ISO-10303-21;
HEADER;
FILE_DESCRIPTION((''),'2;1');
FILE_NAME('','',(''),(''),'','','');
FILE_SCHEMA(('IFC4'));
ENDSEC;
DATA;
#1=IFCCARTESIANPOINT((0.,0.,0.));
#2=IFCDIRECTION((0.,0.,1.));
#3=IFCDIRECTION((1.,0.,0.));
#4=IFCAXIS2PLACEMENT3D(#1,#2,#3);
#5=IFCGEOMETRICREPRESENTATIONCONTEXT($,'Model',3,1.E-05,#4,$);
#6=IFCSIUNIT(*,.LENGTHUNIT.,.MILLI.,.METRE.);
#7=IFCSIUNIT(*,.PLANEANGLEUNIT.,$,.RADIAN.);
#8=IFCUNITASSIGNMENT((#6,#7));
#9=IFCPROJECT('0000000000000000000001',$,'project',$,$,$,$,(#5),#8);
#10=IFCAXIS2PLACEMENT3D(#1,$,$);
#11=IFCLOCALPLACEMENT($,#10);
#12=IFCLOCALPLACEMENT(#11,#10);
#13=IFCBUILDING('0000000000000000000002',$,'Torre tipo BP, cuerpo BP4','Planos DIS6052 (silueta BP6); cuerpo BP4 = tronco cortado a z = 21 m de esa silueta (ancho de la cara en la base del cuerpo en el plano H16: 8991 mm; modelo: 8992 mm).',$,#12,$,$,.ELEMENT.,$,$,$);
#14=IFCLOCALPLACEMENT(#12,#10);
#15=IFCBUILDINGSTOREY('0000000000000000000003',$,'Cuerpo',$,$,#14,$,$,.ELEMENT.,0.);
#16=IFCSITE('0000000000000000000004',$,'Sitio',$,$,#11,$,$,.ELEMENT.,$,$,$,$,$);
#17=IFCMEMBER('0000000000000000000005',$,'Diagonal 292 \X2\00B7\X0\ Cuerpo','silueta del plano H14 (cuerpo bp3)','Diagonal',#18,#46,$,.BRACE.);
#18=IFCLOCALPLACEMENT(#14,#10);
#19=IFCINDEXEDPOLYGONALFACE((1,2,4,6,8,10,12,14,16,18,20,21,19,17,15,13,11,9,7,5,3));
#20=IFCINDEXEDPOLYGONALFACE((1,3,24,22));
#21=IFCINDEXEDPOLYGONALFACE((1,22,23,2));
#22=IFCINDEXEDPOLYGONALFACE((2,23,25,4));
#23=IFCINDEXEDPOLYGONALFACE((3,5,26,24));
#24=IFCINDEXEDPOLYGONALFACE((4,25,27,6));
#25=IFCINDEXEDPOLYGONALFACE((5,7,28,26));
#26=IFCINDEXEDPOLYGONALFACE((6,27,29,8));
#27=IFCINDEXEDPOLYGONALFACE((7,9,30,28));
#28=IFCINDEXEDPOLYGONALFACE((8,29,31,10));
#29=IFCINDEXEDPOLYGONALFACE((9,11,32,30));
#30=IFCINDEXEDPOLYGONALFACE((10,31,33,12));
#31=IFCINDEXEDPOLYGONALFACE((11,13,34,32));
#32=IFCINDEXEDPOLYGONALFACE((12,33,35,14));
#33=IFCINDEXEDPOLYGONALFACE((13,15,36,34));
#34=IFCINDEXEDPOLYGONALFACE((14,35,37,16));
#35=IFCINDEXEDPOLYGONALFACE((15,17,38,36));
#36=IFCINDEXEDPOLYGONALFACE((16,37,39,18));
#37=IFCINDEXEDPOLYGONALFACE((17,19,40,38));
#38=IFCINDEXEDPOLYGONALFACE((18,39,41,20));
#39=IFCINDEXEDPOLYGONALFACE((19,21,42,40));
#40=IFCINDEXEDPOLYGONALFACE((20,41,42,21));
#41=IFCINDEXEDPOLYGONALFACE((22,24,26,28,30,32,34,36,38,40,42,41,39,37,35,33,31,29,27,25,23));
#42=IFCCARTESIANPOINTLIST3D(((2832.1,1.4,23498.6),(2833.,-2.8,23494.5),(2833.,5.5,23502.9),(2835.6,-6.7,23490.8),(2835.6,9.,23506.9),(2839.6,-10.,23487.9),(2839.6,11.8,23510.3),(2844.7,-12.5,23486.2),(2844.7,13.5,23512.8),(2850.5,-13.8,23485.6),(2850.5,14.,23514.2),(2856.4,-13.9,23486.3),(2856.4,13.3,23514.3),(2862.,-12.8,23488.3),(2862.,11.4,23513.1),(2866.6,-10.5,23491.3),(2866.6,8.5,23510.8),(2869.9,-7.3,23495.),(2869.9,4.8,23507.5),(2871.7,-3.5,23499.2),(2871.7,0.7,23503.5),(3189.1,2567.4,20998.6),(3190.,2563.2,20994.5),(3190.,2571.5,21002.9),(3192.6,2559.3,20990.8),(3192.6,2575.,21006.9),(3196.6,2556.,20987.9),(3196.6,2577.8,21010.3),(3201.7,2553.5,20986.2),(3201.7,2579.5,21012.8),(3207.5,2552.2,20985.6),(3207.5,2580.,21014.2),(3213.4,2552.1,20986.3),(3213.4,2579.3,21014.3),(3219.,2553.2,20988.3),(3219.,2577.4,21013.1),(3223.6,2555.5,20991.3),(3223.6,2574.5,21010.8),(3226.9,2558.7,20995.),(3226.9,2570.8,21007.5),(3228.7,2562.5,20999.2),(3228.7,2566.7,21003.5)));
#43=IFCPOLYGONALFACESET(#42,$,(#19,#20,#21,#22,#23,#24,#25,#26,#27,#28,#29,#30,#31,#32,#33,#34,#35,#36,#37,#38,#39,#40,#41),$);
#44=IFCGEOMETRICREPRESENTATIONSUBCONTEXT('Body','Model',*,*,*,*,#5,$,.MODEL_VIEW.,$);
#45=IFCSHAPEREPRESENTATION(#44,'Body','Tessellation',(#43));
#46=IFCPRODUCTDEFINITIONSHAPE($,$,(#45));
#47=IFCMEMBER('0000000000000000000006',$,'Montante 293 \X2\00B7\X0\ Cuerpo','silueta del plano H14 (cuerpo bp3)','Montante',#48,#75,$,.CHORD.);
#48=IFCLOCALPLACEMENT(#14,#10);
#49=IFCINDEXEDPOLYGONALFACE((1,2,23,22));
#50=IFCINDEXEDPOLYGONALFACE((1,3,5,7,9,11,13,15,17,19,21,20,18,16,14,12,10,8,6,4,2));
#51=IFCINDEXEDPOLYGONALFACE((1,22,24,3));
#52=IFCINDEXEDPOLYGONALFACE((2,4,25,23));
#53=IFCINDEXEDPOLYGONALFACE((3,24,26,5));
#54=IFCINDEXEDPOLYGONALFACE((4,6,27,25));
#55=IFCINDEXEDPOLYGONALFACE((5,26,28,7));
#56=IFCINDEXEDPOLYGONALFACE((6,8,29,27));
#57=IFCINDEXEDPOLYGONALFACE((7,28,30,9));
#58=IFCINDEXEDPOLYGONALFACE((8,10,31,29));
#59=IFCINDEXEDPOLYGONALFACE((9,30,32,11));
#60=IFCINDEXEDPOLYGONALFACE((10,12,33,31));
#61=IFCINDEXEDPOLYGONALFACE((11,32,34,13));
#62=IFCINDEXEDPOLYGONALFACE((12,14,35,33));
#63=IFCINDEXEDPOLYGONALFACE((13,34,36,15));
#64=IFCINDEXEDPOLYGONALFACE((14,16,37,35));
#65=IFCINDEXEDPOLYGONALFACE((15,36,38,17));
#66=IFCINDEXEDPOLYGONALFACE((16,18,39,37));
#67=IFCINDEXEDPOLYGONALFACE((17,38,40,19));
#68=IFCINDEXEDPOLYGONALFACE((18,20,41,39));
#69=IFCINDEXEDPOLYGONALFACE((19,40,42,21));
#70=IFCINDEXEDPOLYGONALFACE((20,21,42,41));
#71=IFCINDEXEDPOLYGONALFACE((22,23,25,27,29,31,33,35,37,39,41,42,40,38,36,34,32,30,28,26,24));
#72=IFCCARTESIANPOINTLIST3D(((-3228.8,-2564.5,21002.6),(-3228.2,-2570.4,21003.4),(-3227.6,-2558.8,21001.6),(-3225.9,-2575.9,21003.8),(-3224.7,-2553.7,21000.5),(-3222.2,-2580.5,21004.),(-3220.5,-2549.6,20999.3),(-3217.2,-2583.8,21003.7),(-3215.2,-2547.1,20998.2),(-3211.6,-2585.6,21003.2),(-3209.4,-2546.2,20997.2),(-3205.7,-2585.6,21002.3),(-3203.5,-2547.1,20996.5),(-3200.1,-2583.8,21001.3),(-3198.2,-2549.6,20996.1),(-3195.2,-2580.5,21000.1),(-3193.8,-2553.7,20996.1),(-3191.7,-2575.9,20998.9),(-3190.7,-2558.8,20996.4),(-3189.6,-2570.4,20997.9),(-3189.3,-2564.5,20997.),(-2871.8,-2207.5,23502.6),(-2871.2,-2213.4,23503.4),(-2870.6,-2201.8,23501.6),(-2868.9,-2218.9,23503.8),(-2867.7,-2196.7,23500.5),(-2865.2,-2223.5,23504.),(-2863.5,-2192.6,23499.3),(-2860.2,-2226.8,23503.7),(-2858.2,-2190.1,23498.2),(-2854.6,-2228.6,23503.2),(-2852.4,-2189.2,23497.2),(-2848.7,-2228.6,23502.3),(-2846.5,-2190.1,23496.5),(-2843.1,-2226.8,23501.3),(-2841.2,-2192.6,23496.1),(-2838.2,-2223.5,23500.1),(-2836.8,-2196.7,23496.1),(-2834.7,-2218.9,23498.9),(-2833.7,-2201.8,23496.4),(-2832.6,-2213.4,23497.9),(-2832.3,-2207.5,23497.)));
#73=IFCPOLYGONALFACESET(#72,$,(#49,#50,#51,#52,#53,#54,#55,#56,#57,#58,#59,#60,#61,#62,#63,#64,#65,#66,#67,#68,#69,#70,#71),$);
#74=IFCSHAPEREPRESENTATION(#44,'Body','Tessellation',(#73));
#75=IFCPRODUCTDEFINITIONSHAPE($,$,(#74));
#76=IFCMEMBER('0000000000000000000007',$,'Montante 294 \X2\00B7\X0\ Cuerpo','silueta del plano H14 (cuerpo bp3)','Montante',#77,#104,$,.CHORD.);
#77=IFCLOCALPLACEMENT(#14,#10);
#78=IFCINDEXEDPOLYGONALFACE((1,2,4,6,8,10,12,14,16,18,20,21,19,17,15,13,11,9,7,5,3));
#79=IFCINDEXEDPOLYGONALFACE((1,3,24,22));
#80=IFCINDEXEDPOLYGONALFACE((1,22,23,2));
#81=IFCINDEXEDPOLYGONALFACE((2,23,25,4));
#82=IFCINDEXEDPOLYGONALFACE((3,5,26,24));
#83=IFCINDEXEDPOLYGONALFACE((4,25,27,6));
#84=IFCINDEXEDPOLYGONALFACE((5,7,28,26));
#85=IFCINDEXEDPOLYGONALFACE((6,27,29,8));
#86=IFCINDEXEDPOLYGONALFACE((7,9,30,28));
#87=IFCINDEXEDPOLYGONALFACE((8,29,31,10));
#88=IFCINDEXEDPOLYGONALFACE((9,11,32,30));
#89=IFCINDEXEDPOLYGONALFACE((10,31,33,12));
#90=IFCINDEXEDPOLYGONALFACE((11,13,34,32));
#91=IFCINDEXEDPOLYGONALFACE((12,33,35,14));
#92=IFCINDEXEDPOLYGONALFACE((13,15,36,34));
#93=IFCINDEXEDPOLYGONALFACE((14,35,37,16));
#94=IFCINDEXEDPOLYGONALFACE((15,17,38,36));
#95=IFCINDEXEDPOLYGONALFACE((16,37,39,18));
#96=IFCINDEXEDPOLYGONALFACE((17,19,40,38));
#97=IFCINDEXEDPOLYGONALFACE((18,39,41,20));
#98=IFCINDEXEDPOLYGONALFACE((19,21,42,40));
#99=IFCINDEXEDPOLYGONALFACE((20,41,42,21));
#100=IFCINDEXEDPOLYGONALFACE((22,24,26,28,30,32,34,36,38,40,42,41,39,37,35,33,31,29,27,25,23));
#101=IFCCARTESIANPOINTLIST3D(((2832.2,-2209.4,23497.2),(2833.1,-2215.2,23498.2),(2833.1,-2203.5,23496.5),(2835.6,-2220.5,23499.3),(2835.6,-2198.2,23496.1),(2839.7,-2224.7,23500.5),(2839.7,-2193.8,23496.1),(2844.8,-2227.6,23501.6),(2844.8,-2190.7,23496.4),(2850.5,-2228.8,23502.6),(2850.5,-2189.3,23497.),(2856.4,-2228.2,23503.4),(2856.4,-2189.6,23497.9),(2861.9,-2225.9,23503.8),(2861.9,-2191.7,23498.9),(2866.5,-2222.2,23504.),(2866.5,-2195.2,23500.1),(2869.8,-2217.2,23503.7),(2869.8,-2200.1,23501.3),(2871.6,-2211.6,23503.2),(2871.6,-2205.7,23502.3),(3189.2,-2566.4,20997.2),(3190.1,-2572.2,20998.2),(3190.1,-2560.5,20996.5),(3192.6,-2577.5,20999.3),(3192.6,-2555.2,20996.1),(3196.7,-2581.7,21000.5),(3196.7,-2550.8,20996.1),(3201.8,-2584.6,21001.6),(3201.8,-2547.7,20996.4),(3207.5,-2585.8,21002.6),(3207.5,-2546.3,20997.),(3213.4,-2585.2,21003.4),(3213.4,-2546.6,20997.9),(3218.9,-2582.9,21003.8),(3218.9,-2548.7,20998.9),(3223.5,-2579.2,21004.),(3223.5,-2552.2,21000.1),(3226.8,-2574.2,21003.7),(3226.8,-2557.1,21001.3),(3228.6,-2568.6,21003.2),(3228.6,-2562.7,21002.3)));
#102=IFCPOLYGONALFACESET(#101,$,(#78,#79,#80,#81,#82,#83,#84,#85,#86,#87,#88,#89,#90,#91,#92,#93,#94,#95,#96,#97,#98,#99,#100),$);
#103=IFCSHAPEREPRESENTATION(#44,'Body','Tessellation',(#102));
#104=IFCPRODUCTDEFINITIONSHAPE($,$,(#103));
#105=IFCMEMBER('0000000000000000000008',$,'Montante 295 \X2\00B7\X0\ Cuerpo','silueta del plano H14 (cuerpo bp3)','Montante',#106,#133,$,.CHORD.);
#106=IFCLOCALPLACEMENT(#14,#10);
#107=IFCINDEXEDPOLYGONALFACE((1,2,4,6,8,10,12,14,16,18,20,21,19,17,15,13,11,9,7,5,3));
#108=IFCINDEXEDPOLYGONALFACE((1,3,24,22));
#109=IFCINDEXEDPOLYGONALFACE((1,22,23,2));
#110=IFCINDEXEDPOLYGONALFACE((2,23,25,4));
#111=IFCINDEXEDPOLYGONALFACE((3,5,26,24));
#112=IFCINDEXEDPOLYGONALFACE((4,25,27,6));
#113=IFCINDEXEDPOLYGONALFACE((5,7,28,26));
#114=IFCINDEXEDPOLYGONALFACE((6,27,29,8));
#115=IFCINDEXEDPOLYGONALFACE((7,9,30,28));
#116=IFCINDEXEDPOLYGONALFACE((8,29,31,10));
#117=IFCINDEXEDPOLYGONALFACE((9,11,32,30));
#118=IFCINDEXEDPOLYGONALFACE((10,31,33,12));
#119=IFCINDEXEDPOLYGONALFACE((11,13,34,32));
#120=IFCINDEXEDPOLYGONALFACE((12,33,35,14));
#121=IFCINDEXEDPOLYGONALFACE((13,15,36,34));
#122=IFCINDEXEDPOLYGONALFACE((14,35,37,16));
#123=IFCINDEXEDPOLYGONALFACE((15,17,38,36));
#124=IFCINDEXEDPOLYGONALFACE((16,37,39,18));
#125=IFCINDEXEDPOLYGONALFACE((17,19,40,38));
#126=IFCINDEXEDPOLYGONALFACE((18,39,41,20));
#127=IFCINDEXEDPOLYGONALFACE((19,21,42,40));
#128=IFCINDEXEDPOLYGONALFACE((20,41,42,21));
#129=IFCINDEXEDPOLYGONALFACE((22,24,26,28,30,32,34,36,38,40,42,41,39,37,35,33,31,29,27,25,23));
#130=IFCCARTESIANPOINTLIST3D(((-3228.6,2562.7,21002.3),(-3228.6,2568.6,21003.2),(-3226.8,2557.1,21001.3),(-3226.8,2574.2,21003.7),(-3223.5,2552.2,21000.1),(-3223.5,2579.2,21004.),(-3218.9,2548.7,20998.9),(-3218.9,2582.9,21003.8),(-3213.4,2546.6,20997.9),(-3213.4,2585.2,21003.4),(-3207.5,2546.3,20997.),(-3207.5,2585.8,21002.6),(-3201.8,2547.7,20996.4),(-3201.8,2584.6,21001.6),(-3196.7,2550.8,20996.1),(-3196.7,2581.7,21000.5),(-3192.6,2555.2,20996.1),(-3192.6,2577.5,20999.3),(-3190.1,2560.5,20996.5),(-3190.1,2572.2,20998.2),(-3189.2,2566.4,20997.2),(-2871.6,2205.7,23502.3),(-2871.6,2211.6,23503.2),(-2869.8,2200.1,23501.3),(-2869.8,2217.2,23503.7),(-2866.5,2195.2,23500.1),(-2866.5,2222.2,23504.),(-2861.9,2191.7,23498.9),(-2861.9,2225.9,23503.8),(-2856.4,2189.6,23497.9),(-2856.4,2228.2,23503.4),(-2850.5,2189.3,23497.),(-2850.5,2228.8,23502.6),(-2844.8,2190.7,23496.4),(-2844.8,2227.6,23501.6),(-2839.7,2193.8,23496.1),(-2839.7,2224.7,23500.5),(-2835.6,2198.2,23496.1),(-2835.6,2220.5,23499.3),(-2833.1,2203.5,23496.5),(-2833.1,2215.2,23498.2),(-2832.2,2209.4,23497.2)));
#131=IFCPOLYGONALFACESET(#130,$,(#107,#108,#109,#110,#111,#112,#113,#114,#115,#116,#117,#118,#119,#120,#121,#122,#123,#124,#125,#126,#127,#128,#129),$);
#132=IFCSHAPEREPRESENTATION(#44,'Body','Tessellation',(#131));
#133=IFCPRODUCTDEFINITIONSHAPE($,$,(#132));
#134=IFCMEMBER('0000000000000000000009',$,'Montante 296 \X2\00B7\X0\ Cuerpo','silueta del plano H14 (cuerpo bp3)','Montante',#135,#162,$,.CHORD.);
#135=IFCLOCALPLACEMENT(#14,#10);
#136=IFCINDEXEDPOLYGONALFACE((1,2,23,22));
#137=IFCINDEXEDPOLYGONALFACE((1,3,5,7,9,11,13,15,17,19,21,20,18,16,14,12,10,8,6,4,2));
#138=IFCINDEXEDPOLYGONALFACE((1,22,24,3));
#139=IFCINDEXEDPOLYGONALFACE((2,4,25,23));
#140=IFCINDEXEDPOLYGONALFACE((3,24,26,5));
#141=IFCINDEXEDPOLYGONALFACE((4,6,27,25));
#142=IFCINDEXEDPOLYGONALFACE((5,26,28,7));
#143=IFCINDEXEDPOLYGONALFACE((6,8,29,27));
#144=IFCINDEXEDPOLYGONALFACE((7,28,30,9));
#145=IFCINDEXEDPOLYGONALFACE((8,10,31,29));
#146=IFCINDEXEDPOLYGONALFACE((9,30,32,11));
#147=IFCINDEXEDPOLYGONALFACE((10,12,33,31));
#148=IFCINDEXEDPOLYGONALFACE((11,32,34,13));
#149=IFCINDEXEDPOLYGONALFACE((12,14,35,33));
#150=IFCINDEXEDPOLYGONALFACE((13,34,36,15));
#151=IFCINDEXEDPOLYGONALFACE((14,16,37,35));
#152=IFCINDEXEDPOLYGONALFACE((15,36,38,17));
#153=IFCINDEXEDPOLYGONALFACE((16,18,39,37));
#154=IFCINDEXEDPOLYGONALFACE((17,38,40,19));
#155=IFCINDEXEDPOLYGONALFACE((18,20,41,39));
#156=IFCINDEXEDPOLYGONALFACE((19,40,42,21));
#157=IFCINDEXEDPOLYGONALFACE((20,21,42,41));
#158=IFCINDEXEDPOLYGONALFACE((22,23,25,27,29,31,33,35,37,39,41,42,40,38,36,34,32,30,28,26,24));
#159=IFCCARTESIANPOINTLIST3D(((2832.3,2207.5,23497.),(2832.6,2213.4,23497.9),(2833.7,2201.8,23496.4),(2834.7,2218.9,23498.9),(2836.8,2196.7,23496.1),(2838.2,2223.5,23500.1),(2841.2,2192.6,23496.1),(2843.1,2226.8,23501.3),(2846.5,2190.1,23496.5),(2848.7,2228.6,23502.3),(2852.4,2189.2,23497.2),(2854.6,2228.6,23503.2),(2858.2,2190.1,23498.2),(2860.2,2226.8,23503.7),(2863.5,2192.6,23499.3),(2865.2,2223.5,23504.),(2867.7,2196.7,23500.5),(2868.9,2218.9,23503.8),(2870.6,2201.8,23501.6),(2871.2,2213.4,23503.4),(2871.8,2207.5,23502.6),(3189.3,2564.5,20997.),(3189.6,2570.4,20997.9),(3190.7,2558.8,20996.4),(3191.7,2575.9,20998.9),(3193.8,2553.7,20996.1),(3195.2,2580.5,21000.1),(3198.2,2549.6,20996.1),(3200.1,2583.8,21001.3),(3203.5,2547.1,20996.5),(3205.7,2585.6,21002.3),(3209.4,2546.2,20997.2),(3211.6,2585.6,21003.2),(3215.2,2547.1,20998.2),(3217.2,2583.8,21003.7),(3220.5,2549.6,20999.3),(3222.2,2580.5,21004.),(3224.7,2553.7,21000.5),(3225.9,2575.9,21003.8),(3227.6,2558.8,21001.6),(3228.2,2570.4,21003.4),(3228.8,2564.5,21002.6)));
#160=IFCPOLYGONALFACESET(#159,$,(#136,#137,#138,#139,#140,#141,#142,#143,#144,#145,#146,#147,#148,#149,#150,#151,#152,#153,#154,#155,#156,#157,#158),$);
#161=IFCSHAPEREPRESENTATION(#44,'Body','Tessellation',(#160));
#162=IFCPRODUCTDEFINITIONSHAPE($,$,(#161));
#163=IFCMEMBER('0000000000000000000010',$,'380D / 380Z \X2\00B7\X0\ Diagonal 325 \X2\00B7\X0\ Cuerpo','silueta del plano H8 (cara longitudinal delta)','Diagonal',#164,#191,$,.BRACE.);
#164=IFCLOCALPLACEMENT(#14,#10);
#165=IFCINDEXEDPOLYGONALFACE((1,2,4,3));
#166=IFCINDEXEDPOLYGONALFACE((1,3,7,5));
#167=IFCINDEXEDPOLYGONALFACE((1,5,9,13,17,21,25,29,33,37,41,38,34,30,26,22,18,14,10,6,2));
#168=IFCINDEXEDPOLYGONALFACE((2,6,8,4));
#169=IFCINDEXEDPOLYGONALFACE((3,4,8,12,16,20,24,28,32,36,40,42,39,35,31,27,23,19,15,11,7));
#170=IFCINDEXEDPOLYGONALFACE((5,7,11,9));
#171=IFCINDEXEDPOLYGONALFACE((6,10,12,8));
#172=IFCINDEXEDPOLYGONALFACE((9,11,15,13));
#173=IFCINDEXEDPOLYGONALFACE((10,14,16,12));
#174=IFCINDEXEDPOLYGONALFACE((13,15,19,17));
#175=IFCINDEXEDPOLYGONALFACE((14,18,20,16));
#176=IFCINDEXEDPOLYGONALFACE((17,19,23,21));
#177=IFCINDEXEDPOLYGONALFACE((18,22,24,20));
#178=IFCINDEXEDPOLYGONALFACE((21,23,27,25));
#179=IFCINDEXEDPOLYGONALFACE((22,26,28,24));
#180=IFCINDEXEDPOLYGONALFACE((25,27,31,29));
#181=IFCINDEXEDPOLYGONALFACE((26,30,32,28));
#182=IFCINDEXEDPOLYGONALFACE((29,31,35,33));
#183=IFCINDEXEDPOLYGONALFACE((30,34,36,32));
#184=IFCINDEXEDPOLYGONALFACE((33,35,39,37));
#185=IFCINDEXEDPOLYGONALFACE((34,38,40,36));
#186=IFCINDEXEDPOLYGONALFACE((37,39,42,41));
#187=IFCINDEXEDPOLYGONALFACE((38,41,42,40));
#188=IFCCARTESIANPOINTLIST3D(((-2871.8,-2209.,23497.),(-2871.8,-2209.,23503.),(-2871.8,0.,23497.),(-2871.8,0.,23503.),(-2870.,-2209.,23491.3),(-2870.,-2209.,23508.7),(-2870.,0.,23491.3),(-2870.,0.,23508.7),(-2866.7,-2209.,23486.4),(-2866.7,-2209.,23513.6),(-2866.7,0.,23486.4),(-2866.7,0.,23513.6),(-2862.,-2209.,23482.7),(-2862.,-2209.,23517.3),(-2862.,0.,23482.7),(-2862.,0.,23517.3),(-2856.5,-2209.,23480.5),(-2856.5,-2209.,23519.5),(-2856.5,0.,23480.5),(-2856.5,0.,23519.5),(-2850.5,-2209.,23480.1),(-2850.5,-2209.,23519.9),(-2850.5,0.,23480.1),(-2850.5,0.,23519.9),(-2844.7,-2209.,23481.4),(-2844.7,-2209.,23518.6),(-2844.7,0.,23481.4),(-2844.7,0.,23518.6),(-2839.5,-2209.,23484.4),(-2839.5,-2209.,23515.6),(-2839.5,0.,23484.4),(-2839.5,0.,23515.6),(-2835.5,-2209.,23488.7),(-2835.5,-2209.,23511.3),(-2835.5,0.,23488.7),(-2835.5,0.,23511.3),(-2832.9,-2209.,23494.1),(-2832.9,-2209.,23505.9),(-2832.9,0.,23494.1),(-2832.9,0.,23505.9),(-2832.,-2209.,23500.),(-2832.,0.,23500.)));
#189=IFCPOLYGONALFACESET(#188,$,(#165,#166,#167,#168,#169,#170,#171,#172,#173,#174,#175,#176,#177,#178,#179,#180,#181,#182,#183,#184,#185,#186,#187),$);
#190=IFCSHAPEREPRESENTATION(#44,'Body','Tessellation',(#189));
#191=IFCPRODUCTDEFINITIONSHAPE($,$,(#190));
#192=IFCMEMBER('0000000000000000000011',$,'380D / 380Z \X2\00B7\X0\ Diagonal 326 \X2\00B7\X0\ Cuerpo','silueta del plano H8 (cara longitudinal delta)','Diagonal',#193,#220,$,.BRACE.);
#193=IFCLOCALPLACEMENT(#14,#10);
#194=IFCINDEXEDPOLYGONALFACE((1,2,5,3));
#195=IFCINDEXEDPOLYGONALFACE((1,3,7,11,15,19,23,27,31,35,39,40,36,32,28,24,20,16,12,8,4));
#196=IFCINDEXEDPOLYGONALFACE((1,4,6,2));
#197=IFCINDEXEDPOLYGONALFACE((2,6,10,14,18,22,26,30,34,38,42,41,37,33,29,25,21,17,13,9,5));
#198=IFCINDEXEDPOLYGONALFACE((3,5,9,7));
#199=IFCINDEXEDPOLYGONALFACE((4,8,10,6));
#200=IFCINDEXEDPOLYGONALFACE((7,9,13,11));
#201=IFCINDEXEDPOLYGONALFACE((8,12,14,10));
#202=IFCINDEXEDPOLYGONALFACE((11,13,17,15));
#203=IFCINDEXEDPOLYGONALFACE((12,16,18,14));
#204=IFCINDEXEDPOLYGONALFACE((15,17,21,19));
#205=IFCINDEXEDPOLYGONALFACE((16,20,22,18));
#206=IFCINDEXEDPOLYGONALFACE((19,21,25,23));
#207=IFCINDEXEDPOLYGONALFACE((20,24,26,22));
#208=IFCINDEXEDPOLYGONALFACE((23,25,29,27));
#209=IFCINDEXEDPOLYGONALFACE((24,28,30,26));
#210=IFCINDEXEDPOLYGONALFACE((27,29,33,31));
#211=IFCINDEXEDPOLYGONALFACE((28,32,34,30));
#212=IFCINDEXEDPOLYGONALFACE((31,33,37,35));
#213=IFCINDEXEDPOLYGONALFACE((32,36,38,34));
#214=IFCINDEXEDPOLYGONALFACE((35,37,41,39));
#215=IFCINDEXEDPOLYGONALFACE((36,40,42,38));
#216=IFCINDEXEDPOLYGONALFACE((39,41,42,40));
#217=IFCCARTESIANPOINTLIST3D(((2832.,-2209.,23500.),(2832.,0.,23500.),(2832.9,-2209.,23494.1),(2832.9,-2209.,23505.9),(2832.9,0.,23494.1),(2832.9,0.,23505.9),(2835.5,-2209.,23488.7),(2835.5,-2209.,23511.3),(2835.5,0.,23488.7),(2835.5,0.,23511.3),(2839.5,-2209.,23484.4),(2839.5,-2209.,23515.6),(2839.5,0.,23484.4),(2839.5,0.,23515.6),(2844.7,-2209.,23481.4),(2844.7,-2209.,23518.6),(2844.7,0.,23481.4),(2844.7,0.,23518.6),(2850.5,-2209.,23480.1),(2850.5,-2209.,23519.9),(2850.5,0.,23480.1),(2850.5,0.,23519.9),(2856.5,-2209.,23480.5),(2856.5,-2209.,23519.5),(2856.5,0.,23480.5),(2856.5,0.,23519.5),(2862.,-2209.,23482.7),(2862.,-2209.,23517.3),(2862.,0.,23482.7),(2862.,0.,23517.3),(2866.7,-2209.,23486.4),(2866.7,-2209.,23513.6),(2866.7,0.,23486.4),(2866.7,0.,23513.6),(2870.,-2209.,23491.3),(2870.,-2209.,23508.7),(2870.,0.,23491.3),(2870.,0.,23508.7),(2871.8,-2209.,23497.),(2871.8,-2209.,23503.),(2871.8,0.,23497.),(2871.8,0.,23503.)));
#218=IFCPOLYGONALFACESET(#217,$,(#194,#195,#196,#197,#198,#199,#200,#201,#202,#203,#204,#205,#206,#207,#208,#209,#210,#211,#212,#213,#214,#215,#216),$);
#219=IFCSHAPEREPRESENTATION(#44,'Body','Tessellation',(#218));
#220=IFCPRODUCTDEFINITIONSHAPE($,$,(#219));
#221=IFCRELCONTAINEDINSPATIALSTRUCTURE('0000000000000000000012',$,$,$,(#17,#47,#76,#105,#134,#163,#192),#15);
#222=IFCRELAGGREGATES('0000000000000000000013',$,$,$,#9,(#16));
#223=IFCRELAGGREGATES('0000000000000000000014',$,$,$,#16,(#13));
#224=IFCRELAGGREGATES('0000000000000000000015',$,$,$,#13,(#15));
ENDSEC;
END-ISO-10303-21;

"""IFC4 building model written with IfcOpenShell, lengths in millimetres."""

from ifc_helpers import new_model, si_unit, frame, origin, origin_with_axes, place, context, subcontext, project, spatial, circle, extrude, element, save


model = new_model("IFC4")

# Units and contexts
model_context = context("Model", 3, precision=1e-05, world=origin_with_axes())
body_context = subcontext(model_context, "Body", "Model", "MODEL_VIEW")
ifc_project = project(units=[si_unit("LENGTHUNIT", "METRE", prefix="MILLI"), si_unit("PLANEANGLEUNIT", "RADIAN")], contexts=[model_context])

# Site, building, storey
site_placement = place(None, origin())
site = spatial("IfcSite", under=ifc_project, at=site_placement, Name="Sitio", CompositionType="ELEMENT")
building_placement = place(site_placement, origin())
building = spatial("IfcBuilding", under=site, at=building_placement, Name="Torre tipo BP, cuerpo BP4", Description="Planos DIS6052 (silueta BP6); cuerpo BP4 = tronco cortado a z = 21 m de esa silueta (ancho de la cara en la base del cuerpo en el plano H16: 8991 mm; modelo: 8992 mm).", CompositionType="ELEMENT")
storey_placement = place(building_placement, origin())
storey = spatial("IfcBuildingStorey", under=building, at=storey_placement, Name="Cuerpo", CompositionType="ELEMENT", Elevation=0.0)

# Members
for number, where, z_axis, x_axis, name in (
    (1, (2852.0, 0.0, 23500.0), (0.09916, 0.712728, -0.694396), (-0.995072, 0.071024, -0.069197), "Diagonal 292 · Cuerpo"),
):
    element("IfcMember", number, at=place(storey_placement, frame(where, z_axis=z_axis, x_axis=x_axis)), inside=storey, Name=name, Description="silueta del plano H14 (cuerpo bp3)", ObjectType="Diagonal", PredefinedType="BRACE", context=body_context, shape_type="SweptSolid", body=[
        extrude(circle(Radius=20.0), None, (0.0, 0.0, 1.0), 3600.3),
    ])
for number, where, z_axis, x_axis, name in (
    (2, (-2852.0, -2209.0, 23500.0), (-0.139974, -0.139974, -0.980211), (-0.019788, 0.990155, -0.138568), "Montante 293 · Cuerpo"),
    (3, (2852.0, -2209.0, 23500.0), (0.139974, -0.139974, -0.980211), (-0.990155, -0.019788, -0.138568), "Montante 294 · Cuerpo"),
    (4, (-2852.0, 2209.0, 23500.0), (-0.139974, 0.139974, -0.980211), (0.990155, 0.019788, -0.138568), "Montante 295 · Cuerpo"),
    (5, (2852.0, 2209.0, 23500.0), (0.139974, 0.139974, -0.980211), (0.019788, -0.990155, -0.138568), "Montante 296 · Cuerpo"),
):
    element("IfcMember", number, at=place(storey_placement, frame(where, z_axis=z_axis, x_axis=x_axis)), inside=storey, Name=name, Description="silueta del plano H14 (cuerpo bp3)", ObjectType="Montante", PredefinedType="CHORD", context=body_context, shape_type="SweptSolid", body=[
        extrude(circle(Radius=20.0), None, (0.0, 0.0, 1.0), 2550.5),
    ])
for number, where, z_axis, x_axis, name in (
    (6, (-2852.0, -2209.0, 23500.0), (0.0, 1.0, 0.0), (1.0, 0.0, 0.0), "380D / 380Z · Diagonal 325 · Cuerpo"),
    (7, (2852.0, -2209.0, 23500.0), (0.0, 1.0, 0.0), (-1.0, 0.0, 0.0), "380D / 380Z · Diagonal 326 · Cuerpo"),
):
    element("IfcMember", number, at=place(storey_placement, frame(where, z_axis=z_axis, x_axis=x_axis)), inside=storey, Name=name, Description="silueta del plano H8 (cara longitudinal delta)", ObjectType="Diagonal", PredefinedType="BRACE", context=body_context, shape_type="SweptSolid", body=[
        extrude(circle(Radius=20.0), None, (0.0, 0.0, 1.0), 2209.0),
    ])

save(model, "model.ifc")
